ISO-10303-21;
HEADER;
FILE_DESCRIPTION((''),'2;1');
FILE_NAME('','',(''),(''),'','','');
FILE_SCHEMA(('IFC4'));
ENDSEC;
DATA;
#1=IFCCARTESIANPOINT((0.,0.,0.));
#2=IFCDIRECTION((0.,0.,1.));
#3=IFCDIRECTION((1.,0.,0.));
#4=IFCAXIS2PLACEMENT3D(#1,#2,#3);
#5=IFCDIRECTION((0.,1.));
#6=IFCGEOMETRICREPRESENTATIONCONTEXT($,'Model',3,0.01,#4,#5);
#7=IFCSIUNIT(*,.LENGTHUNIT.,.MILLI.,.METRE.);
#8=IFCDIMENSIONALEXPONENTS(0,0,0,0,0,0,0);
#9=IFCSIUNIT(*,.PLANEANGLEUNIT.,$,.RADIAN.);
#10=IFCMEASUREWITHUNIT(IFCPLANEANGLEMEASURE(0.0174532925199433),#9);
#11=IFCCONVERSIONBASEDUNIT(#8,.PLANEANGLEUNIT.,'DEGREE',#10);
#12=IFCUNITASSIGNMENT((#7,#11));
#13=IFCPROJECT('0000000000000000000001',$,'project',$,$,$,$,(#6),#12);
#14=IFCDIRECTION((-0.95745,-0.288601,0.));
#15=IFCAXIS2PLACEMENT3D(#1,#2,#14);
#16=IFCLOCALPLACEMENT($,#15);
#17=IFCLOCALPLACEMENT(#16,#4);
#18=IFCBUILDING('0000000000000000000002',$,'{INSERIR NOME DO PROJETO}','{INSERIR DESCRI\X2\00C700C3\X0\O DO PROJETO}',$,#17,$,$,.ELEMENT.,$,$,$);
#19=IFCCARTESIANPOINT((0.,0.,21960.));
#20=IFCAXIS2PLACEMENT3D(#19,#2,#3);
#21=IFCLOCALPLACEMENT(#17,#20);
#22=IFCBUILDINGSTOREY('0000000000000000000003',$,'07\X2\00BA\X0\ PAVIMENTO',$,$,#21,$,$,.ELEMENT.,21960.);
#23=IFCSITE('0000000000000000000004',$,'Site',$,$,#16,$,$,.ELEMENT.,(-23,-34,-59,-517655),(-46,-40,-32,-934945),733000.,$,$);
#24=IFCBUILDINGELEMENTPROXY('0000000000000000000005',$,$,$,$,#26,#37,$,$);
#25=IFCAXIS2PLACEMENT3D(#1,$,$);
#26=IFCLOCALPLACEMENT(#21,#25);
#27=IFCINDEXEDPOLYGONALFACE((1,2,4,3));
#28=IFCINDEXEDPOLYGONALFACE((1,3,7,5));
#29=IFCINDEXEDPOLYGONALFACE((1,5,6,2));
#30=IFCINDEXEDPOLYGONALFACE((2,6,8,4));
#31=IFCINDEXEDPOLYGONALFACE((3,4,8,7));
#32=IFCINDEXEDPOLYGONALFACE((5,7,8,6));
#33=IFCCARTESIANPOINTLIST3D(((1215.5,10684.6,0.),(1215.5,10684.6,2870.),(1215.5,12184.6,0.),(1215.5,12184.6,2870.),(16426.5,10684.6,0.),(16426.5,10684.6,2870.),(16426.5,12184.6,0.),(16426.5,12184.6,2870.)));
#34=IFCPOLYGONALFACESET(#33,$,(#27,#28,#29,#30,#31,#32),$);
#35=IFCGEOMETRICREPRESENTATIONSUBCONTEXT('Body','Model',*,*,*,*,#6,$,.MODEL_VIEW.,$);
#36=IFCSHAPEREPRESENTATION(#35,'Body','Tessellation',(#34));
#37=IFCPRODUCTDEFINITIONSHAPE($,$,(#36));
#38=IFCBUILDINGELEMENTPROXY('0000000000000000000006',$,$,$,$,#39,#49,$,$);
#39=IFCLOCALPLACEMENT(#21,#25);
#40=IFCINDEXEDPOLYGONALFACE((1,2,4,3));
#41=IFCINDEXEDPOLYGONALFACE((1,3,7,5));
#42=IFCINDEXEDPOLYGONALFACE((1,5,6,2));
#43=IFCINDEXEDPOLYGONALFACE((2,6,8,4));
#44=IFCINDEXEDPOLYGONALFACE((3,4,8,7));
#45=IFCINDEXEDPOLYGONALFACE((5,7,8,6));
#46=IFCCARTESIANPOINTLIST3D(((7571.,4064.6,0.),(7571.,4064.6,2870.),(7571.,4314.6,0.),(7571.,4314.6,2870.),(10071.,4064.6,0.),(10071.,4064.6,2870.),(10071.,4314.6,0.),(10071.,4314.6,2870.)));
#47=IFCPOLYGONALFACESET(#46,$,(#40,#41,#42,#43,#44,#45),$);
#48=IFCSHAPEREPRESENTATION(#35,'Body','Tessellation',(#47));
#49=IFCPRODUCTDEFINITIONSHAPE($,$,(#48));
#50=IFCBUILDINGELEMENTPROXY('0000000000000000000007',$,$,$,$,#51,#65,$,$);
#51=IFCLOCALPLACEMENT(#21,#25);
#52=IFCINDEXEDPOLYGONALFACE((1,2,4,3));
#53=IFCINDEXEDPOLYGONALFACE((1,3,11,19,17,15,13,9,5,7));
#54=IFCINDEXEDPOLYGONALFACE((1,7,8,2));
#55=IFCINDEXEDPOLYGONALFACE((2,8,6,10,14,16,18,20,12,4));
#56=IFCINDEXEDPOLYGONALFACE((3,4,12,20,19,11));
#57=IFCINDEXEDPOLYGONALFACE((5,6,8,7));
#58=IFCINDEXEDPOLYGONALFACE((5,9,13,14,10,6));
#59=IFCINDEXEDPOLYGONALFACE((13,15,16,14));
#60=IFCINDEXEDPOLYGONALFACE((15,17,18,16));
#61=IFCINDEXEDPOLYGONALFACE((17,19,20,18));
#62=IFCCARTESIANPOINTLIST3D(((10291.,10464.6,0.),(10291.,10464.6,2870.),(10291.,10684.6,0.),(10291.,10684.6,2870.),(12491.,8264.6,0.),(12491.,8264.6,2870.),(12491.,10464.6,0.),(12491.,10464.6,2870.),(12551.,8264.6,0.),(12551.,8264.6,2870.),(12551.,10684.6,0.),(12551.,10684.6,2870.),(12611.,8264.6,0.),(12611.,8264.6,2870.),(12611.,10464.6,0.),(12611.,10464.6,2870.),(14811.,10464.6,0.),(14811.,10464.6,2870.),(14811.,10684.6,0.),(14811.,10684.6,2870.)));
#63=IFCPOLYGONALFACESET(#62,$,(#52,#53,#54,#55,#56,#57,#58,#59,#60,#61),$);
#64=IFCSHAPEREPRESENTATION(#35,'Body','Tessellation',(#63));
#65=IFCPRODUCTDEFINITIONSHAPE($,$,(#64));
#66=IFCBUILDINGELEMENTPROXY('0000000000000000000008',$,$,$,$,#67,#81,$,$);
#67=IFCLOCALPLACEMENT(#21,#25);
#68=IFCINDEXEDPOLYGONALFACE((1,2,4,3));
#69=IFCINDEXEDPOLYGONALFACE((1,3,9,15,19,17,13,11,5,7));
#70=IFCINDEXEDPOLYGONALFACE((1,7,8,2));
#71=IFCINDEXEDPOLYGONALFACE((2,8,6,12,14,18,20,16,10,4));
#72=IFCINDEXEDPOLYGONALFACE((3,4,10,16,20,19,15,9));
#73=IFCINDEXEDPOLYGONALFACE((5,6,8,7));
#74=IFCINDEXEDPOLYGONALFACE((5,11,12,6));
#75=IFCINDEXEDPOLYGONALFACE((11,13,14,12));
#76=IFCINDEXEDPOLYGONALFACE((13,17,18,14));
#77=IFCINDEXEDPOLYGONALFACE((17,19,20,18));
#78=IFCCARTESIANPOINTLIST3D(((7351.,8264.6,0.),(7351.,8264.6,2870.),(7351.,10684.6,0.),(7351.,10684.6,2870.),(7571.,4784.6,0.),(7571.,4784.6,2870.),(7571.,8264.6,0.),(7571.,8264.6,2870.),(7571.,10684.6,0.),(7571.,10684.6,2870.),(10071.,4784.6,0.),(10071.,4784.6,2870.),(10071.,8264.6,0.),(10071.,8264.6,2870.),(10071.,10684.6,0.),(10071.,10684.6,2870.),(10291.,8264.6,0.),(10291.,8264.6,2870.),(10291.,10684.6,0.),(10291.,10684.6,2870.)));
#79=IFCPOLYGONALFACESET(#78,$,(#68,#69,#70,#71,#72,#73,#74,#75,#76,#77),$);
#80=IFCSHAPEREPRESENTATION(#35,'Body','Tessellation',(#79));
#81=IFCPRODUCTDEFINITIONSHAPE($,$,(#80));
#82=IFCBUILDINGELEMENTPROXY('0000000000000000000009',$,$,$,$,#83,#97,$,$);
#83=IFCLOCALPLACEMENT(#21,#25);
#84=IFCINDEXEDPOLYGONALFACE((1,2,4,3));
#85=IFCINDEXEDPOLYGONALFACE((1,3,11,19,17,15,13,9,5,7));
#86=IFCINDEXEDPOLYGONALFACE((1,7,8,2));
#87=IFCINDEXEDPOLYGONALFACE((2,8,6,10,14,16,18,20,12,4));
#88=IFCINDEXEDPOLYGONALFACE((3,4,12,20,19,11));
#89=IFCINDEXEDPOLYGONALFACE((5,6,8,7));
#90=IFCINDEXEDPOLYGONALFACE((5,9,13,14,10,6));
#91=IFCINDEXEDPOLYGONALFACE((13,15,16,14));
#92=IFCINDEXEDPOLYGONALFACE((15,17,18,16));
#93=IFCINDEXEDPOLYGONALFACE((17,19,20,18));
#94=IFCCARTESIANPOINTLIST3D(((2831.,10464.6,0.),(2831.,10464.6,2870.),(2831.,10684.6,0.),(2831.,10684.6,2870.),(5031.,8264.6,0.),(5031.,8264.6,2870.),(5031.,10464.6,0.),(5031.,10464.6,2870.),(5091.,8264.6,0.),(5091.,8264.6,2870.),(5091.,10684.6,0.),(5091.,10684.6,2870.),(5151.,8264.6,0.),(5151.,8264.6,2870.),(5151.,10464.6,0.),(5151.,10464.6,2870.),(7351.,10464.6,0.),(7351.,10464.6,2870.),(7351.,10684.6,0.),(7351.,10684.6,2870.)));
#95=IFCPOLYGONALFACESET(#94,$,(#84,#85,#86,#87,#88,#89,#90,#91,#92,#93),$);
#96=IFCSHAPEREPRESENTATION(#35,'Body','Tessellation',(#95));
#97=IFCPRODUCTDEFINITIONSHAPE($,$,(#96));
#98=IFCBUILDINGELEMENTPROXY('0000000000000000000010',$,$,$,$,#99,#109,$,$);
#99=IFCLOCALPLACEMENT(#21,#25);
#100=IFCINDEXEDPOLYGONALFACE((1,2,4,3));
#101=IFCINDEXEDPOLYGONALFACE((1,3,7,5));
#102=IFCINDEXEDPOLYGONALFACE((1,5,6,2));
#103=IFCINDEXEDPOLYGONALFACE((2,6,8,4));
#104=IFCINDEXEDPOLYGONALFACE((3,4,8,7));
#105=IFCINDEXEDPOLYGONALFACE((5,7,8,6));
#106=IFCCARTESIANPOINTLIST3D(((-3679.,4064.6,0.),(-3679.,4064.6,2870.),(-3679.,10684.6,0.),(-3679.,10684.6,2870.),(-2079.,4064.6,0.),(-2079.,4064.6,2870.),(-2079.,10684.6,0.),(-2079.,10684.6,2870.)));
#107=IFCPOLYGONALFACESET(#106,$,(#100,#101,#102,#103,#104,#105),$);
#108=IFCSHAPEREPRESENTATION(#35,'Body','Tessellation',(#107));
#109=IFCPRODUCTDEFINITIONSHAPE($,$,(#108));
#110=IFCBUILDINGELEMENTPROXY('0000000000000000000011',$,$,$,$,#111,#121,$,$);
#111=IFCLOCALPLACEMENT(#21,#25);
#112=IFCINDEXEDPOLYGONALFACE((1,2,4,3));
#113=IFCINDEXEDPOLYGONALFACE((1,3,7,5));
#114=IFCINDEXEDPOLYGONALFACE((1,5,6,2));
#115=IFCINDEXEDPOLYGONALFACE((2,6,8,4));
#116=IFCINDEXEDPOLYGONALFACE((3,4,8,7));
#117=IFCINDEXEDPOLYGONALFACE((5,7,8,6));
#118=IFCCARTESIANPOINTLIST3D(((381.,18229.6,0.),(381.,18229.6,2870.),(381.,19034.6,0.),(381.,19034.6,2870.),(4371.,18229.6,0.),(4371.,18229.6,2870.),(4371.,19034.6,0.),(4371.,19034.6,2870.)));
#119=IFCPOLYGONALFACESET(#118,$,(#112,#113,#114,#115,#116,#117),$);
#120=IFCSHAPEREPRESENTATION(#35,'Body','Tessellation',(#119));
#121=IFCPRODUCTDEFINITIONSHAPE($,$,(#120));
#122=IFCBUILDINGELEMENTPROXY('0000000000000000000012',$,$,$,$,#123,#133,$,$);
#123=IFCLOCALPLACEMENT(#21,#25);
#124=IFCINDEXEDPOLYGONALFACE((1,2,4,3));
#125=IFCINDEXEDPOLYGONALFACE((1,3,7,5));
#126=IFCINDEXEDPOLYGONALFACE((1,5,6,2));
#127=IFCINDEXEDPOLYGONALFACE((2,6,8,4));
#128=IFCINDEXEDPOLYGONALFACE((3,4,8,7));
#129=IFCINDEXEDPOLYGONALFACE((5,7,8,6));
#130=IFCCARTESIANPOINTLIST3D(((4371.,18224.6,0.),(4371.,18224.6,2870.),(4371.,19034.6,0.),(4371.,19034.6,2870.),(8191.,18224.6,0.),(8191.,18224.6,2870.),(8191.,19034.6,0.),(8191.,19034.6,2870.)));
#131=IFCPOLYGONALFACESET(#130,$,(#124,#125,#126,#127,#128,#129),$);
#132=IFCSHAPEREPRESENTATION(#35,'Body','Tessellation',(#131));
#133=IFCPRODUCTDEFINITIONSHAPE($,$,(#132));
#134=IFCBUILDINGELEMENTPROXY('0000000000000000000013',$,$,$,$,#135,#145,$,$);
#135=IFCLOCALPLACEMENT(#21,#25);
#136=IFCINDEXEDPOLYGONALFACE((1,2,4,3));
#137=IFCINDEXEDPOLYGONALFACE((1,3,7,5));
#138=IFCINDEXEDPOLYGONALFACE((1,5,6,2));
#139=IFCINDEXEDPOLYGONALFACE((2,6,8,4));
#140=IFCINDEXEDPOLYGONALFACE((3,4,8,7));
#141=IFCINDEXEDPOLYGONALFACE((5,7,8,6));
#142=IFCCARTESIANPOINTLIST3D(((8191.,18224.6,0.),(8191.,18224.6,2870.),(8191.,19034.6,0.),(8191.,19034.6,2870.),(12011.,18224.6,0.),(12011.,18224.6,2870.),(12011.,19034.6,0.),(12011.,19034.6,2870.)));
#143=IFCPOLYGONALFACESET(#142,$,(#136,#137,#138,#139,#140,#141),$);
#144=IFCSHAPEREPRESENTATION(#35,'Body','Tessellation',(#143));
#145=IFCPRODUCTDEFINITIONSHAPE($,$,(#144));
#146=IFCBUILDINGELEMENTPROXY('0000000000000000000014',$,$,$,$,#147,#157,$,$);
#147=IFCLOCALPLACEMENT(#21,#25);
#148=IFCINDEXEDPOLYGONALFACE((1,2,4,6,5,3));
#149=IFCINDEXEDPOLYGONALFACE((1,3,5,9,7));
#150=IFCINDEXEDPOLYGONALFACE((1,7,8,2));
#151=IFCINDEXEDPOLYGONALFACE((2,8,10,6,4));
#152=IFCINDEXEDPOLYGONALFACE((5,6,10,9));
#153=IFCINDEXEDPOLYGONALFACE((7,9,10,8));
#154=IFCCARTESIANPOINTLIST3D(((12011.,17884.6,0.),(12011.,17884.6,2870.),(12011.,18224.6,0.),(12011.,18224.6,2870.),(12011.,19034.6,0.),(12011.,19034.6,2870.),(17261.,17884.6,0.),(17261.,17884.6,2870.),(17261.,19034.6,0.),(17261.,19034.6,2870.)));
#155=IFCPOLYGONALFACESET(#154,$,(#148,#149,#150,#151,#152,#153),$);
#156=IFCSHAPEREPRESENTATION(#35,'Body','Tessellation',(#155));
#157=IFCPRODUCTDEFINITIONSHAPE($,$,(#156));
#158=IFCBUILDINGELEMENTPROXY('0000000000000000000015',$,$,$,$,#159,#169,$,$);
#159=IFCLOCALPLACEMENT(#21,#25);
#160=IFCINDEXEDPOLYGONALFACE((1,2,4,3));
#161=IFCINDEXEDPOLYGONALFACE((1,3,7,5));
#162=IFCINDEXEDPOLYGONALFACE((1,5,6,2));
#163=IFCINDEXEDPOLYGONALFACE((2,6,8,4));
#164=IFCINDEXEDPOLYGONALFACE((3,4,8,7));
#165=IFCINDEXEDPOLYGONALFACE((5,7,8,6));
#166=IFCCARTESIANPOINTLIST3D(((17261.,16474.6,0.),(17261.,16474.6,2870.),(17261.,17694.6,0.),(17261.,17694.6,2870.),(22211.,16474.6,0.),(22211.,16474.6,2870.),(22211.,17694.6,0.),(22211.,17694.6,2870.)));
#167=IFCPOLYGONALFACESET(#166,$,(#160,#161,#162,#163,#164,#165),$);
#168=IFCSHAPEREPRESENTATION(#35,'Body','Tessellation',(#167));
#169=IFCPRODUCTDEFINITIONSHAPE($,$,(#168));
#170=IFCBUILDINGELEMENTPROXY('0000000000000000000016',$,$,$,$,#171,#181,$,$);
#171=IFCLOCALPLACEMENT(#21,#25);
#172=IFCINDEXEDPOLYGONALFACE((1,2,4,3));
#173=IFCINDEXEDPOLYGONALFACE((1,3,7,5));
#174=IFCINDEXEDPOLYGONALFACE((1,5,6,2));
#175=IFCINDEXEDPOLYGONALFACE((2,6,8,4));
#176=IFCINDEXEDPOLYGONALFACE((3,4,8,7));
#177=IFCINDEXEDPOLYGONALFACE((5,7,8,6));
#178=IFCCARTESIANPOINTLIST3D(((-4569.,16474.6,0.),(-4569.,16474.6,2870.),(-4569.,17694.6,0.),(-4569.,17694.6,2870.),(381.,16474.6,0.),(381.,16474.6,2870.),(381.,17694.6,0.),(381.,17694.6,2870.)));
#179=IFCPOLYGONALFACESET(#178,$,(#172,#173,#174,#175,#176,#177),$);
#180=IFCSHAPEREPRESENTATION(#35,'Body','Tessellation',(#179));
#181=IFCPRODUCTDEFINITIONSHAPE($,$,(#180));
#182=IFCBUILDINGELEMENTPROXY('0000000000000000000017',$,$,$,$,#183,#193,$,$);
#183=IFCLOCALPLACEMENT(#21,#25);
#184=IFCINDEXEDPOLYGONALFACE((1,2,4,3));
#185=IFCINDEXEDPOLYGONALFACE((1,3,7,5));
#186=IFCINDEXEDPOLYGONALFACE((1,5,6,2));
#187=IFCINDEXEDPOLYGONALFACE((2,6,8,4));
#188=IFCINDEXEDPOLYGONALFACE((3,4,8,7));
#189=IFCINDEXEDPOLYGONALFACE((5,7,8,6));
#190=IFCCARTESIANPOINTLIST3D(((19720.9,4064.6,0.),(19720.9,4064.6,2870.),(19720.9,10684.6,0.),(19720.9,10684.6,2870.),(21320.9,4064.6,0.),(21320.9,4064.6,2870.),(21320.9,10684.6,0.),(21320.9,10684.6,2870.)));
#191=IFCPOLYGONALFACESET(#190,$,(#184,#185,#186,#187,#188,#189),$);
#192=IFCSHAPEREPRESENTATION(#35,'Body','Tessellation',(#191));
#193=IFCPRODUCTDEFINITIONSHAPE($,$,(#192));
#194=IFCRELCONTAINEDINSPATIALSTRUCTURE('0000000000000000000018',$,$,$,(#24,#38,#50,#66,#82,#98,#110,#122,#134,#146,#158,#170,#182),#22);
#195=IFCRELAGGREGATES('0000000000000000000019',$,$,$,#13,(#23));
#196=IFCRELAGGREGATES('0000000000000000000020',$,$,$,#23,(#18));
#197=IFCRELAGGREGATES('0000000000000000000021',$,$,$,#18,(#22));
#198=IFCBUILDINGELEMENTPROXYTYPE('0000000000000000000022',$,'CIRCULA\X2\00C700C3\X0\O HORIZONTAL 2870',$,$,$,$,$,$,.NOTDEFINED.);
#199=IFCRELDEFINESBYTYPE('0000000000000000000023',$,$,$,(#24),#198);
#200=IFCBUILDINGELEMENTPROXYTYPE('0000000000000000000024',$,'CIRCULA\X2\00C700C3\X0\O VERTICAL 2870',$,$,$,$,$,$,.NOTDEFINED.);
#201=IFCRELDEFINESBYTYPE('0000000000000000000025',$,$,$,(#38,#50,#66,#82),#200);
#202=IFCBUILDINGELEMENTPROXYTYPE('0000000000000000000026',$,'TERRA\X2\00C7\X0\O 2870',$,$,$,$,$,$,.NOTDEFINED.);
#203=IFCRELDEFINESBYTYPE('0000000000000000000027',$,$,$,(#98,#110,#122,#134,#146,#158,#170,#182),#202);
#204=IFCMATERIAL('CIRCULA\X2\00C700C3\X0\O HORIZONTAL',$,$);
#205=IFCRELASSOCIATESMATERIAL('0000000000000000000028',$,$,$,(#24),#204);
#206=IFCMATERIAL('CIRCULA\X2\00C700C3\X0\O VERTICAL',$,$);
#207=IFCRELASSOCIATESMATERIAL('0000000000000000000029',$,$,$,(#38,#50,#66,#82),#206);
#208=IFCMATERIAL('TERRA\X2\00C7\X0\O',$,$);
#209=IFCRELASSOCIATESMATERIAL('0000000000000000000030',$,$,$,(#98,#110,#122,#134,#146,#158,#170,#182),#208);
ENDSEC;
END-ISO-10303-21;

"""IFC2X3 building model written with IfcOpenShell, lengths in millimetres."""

from ifc_helpers import new_model, entity, si_unit, converted_unit, direction, frame, origin_with_axes, place, context, subcontext, project, spatial, polyline, outline, extrude, material, type_object, element, save


model = new_model("IFC2X3")

# Units and contexts
model_context = context("Model", 3, precision=0.01, world=origin_with_axes(), true_north=direction((0.0, 1.0)))
body_context = subcontext(model_context, "Body", "Model", "MODEL_VIEW")
ifc_project = project(units=[si_unit("LENGTHUNIT", "METRE", prefix="MILLI"), converted_unit("PLANEANGLEUNIT", "DEGREE", entity("IfcPlaneAngleMeasure", 0.0174532925199433), si_unit("PLANEANGLEUNIT", "RADIAN"), dimensions=[0, 0, 0, 0, 0, 0, 0])], contexts=[model_context])

# Site, building, storey
site_placement = place(None, frame((0.0, 0.0, 0.0), z_axis=(0.0, 0.0, 1.0), x_axis=(-0.95745, -0.288601, 0.0)))
site = spatial("IfcSite", under=ifc_project, at=site_placement, Name="Site", CompositionType="ELEMENT", RefLatitude=(-23, -34, -59, -517655), RefLongitude=(-46, -40, -32, -934945), RefElevation=733000.0)
building_placement = place(site_placement, origin_with_axes())
building = spatial("IfcBuilding", under=site, at=building_placement, Name="{INSERIR NOME DO PROJETO}", Description="{INSERIR DESCRIÇÃO DO PROJETO}", CompositionType="ELEMENT")
storey_placement = place(building_placement, frame((0.0, 0.0, 21960.0), z_axis=(0.0, 0.0, 1.0), x_axis=(1.0, 0.0, 0.0)))
storey = spatial("IfcBuildingStorey", under=building, at=storey_placement, Name="07º PAVIMENTO", CompositionType="ELEMENT", Elevation=21960.0)

# Building element proxies
ifc_material_1 = material(Name="CIRCULAÇÃO HORIZONTAL")
building_element_proxy_type_1 = type_object("IfcBuildingElementProxyType", Name="CIRCULAÇÃO HORIZONTAL 2870", PredefinedType="NOTDEFINED")
proxy_1_placement = place(storey_placement, frame((1215.5, 10684.6, 0.0), z_axis=(0.0, 0.0, 1.0), x_axis=(1.0, 0.0, 0.0)))
element("IfcBuildingElementProxy", 1, at=proxy_1_placement, inside=storey, type_object=building_element_proxy_type_1, material=ifc_material_1, context=body_context, shape_type="SweptSolid", body=[
    extrude(outline(polyline([(0.0, 0.0), (15211.0, 0.0), (15211.0, 1500.0), (0.0, 1500.0), (0.0, 0.0)])), origin_with_axes(), (0.0, 0.0, 1.0), 2870.0),
])
ifc_material_2 = material(Name="CIRCULAÇÃO VERTICAL")
building_element_proxy_type_2 = type_object("IfcBuildingElementProxyType", Name="CIRCULAÇÃO VERTICAL 2870", PredefinedType="NOTDEFINED")
proxy_2_placement = place(storey_placement, frame((7571.0, 4064.6, 0.0), z_axis=(0.0, 0.0, 1.0), x_axis=(1.0, 0.0, 0.0)))
element("IfcBuildingElementProxy", 2, at=proxy_2_placement, inside=storey, type_object=building_element_proxy_type_2, material=ifc_material_2, context=body_context, shape_type="SweptSolid", body=[
    extrude(outline(polyline([(0.0, 0.0), (2500.0, 0.0), (2500.0, 250.0), (0.0, 250.0), (0.0, 0.0)])), origin_with_axes(), (0.0, 0.0, 1.0), 2870.0),
])
proxy_3_placement = place(storey_placement, frame((10291.0, 10684.6, 0.0), z_axis=(0.0, 0.0, 1.0), x_axis=(1.0, 0.0, 0.0)))
element("IfcBuildingElementProxy", 3, at=proxy_3_placement, inside=storey, type_object=building_element_proxy_type_2, material=ifc_material_2, context=body_context, shape_type="SweptSolid", body=[
    extrude(outline(polyline([(0.0, 0.0), (0.0, -220.0), (2200.0, -220.0), (2200.0, -2420.0), (2260.0, -2420.0), (2320.0, -2420.0), (2320.0, -220.0), (4520.0, -220.0), (4520.0, 0.0), (2260.0, 0.0), (0.0, 0.0)])), origin_with_axes(), (0.0, 0.0, 1.0), 2870.0),
])
proxy_4_placement = place(storey_placement, frame((7351.0, 10684.6, 0.0), z_axis=(0.0, 0.0, 1.0), x_axis=(1.0, 0.0, 0.0)))
element("IfcBuildingElementProxy", 4, at=proxy_4_placement, inside=storey, type_object=building_element_proxy_type_2, material=ifc_material_2, context=body_context, shape_type="SweptSolid", body=[
    extrude(outline(polyline([(0.0, 0.0), (0.0, -2420.0), (220.0, -2420.0), (220.0, -5900.0), (2720.0, -5900.0), (2720.0, -2420.0), (2940.0, -2420.0), (2940.0, 0.0), (2720.0, 0.0), (220.0, 0.0), (0.0, 0.0)])), origin_with_axes(), (0.0, 0.0, 1.0), 2870.0),
])
proxy_5_placement = place(storey_placement, frame((5091.0, 10684.6, 0.0), z_axis=(0.0, 0.0, 1.0), x_axis=(1.0, 0.0, 0.0)))
element("IfcBuildingElementProxy", 5, at=proxy_5_placement, inside=storey, type_object=building_element_proxy_type_2, material=ifc_material_2, context=body_context, shape_type="SweptSolid", body=[
    extrude(outline(polyline([(0.0, 0.0), (-2260.0, 0.0), (-2260.0, -220.0), (-60.0, -220.0), (-60.0, -2420.0), (0.0, -2420.0), (60.0, -2420.0), (60.0, -220.0), (2260.0, -220.0), (2260.0, 0.0), (0.0, 0.0)])), origin_with_axes(), (0.0, 0.0, 1.0), 2870.0),
])
ifc_material_3 = material(Name="TERRAÇO")
building_element_proxy_type_3 = type_object("IfcBuildingElementProxyType", Name="TERRAÇO 2870", PredefinedType="NOTDEFINED")
proxy_6_placement = place(storey_placement, frame((-3679.0, 4064.6, 0.0), z_axis=(0.0, 0.0, 1.0), x_axis=(1.0, 0.0, 0.0)))
element("IfcBuildingElementProxy", 6, at=proxy_6_placement, inside=storey, type_object=building_element_proxy_type_3, material=ifc_material_3, context=body_context, shape_type="SweptSolid", body=[
    extrude(outline(polyline([(0.0, 0.0), (1600.0, 0.0), (1600.0, 6620.0), (0.0, 6620.0), (0.0, 0.0)])), origin_with_axes(), (0.0, 0.0, 1.0), 2870.0),
])
proxy_7_placement = place(storey_placement, frame((381.0, 19034.6, 0.0), z_axis=(0.0, 0.0, 1.0), x_axis=(1.0, 0.0, 0.0)))
element("IfcBuildingElementProxy", 7, at=proxy_7_placement, inside=storey, type_object=building_element_proxy_type_3, material=ifc_material_3, context=body_context, shape_type="SweptSolid", body=[
    extrude(outline(polyline([(0.0, 0.0), (0.0, -805.0), (3990.0, -805.0), (3990.0, 0.0), (0.0, 0.0)])), origin_with_axes(), (0.0, 0.0, 1.0), 2870.0),
])
for number, where, z_axis, x_axis in (
    (8, (4371.0, 18224.6, 0.0), (0.0, 0.0, 1.0), (1.0, 0.0, 0.0)),
    (9, (8191.0, 18224.6, 0.0), (0.0, 0.0, 1.0), (1.0, 0.0, 0.0)),
):
    element("IfcBuildingElementProxy", number, at=place(storey_placement, frame(where, z_axis=z_axis, x_axis=x_axis)), inside=storey, type_object=building_element_proxy_type_3, material=ifc_material_3, context=body_context, shape_type="SweptSolid", body=[
        extrude(outline(polyline([(0.0, 0.0), (3820.0, 0.0), (3820.0, 810.0), (0.0, 810.0), (0.0, 0.0)])), origin_with_axes(), (0.0, 0.0, 1.0), 2870.0),
    ])
proxy_8_placement = place(storey_placement, frame((12011.0, 19034.6, 0.0), z_axis=(0.0, 0.0, 1.0), x_axis=(1.0, 0.0, 0.0)))
element("IfcBuildingElementProxy", 10, at=proxy_8_placement, inside=storey, type_object=building_element_proxy_type_3, material=ifc_material_3, context=body_context, shape_type="SweptSolid", body=[
    extrude(outline(polyline([(0.0, 0.0), (0.0, -810.0), (0.0, -1150.0), (5250.0, -1150.0), (5250.0, 0.0), (0.0, 0.0)])), origin_with_axes(), (0.0, 0.0, 1.0), 2870.0),
])
proxy_9_placement = place(storey_placement, frame((17261.0, 16474.6, 0.0), z_axis=(0.0, 0.0, 1.0), x_axis=(1.0, 0.0, 0.0)))
element("IfcBuildingElementProxy", 11, at=proxy_9_placement, inside=storey, type_object=building_element_proxy_type_3, material=ifc_material_3, context=body_context, shape_type="SweptSolid", body=[
    extrude(outline(polyline([(0.0, 0.0), (4950.0, 0.0), (4950.0, 1220.0), (0.0, 1220.0), (0.0, 0.0)])), origin_with_axes(), (0.0, 0.0, 1.0), 2870.0),
])
proxy_10_placement = place(storey_placement, frame((381.0, 17694.6, 0.0), z_axis=(0.0, 0.0, 1.0), x_axis=(1.0, 0.0, 0.0)))
element("IfcBuildingElementProxy", 12, at=proxy_10_placement, inside=storey, type_object=building_element_proxy_type_3, material=ifc_material_3, context=body_context, shape_type="SweptSolid", body=[
    extrude(outline(polyline([(0.0, 0.0), (-4950.0, 0.0), (-4950.0, -1220.0), (0.0, -1220.0), (0.0, 0.0)])), origin_with_axes(), (0.0, 0.0, 1.0), 2870.0),
])
proxy_11_placement = place(storey_placement, frame((21320.9, 4064.6, 0.0), z_axis=(0.0, 0.0, 1.0), x_axis=(1.0, 0.0, 0.0)))
element("IfcBuildingElementProxy", 13, at=proxy_11_placement, inside=storey, type_object=building_element_proxy_type_3, material=ifc_material_3, context=body_context, shape_type="SweptSolid", body=[
    extrude(outline(polyline([(0.0, 0.0), (0.0, 6620.0), (-1600.0, 6620.0), (-1600.0, 0.0), (0.0, 0.0)])), origin_with_axes(), (0.0, 0.0, 1.0), 2870.0),
])

save(model, "model.ifc")
